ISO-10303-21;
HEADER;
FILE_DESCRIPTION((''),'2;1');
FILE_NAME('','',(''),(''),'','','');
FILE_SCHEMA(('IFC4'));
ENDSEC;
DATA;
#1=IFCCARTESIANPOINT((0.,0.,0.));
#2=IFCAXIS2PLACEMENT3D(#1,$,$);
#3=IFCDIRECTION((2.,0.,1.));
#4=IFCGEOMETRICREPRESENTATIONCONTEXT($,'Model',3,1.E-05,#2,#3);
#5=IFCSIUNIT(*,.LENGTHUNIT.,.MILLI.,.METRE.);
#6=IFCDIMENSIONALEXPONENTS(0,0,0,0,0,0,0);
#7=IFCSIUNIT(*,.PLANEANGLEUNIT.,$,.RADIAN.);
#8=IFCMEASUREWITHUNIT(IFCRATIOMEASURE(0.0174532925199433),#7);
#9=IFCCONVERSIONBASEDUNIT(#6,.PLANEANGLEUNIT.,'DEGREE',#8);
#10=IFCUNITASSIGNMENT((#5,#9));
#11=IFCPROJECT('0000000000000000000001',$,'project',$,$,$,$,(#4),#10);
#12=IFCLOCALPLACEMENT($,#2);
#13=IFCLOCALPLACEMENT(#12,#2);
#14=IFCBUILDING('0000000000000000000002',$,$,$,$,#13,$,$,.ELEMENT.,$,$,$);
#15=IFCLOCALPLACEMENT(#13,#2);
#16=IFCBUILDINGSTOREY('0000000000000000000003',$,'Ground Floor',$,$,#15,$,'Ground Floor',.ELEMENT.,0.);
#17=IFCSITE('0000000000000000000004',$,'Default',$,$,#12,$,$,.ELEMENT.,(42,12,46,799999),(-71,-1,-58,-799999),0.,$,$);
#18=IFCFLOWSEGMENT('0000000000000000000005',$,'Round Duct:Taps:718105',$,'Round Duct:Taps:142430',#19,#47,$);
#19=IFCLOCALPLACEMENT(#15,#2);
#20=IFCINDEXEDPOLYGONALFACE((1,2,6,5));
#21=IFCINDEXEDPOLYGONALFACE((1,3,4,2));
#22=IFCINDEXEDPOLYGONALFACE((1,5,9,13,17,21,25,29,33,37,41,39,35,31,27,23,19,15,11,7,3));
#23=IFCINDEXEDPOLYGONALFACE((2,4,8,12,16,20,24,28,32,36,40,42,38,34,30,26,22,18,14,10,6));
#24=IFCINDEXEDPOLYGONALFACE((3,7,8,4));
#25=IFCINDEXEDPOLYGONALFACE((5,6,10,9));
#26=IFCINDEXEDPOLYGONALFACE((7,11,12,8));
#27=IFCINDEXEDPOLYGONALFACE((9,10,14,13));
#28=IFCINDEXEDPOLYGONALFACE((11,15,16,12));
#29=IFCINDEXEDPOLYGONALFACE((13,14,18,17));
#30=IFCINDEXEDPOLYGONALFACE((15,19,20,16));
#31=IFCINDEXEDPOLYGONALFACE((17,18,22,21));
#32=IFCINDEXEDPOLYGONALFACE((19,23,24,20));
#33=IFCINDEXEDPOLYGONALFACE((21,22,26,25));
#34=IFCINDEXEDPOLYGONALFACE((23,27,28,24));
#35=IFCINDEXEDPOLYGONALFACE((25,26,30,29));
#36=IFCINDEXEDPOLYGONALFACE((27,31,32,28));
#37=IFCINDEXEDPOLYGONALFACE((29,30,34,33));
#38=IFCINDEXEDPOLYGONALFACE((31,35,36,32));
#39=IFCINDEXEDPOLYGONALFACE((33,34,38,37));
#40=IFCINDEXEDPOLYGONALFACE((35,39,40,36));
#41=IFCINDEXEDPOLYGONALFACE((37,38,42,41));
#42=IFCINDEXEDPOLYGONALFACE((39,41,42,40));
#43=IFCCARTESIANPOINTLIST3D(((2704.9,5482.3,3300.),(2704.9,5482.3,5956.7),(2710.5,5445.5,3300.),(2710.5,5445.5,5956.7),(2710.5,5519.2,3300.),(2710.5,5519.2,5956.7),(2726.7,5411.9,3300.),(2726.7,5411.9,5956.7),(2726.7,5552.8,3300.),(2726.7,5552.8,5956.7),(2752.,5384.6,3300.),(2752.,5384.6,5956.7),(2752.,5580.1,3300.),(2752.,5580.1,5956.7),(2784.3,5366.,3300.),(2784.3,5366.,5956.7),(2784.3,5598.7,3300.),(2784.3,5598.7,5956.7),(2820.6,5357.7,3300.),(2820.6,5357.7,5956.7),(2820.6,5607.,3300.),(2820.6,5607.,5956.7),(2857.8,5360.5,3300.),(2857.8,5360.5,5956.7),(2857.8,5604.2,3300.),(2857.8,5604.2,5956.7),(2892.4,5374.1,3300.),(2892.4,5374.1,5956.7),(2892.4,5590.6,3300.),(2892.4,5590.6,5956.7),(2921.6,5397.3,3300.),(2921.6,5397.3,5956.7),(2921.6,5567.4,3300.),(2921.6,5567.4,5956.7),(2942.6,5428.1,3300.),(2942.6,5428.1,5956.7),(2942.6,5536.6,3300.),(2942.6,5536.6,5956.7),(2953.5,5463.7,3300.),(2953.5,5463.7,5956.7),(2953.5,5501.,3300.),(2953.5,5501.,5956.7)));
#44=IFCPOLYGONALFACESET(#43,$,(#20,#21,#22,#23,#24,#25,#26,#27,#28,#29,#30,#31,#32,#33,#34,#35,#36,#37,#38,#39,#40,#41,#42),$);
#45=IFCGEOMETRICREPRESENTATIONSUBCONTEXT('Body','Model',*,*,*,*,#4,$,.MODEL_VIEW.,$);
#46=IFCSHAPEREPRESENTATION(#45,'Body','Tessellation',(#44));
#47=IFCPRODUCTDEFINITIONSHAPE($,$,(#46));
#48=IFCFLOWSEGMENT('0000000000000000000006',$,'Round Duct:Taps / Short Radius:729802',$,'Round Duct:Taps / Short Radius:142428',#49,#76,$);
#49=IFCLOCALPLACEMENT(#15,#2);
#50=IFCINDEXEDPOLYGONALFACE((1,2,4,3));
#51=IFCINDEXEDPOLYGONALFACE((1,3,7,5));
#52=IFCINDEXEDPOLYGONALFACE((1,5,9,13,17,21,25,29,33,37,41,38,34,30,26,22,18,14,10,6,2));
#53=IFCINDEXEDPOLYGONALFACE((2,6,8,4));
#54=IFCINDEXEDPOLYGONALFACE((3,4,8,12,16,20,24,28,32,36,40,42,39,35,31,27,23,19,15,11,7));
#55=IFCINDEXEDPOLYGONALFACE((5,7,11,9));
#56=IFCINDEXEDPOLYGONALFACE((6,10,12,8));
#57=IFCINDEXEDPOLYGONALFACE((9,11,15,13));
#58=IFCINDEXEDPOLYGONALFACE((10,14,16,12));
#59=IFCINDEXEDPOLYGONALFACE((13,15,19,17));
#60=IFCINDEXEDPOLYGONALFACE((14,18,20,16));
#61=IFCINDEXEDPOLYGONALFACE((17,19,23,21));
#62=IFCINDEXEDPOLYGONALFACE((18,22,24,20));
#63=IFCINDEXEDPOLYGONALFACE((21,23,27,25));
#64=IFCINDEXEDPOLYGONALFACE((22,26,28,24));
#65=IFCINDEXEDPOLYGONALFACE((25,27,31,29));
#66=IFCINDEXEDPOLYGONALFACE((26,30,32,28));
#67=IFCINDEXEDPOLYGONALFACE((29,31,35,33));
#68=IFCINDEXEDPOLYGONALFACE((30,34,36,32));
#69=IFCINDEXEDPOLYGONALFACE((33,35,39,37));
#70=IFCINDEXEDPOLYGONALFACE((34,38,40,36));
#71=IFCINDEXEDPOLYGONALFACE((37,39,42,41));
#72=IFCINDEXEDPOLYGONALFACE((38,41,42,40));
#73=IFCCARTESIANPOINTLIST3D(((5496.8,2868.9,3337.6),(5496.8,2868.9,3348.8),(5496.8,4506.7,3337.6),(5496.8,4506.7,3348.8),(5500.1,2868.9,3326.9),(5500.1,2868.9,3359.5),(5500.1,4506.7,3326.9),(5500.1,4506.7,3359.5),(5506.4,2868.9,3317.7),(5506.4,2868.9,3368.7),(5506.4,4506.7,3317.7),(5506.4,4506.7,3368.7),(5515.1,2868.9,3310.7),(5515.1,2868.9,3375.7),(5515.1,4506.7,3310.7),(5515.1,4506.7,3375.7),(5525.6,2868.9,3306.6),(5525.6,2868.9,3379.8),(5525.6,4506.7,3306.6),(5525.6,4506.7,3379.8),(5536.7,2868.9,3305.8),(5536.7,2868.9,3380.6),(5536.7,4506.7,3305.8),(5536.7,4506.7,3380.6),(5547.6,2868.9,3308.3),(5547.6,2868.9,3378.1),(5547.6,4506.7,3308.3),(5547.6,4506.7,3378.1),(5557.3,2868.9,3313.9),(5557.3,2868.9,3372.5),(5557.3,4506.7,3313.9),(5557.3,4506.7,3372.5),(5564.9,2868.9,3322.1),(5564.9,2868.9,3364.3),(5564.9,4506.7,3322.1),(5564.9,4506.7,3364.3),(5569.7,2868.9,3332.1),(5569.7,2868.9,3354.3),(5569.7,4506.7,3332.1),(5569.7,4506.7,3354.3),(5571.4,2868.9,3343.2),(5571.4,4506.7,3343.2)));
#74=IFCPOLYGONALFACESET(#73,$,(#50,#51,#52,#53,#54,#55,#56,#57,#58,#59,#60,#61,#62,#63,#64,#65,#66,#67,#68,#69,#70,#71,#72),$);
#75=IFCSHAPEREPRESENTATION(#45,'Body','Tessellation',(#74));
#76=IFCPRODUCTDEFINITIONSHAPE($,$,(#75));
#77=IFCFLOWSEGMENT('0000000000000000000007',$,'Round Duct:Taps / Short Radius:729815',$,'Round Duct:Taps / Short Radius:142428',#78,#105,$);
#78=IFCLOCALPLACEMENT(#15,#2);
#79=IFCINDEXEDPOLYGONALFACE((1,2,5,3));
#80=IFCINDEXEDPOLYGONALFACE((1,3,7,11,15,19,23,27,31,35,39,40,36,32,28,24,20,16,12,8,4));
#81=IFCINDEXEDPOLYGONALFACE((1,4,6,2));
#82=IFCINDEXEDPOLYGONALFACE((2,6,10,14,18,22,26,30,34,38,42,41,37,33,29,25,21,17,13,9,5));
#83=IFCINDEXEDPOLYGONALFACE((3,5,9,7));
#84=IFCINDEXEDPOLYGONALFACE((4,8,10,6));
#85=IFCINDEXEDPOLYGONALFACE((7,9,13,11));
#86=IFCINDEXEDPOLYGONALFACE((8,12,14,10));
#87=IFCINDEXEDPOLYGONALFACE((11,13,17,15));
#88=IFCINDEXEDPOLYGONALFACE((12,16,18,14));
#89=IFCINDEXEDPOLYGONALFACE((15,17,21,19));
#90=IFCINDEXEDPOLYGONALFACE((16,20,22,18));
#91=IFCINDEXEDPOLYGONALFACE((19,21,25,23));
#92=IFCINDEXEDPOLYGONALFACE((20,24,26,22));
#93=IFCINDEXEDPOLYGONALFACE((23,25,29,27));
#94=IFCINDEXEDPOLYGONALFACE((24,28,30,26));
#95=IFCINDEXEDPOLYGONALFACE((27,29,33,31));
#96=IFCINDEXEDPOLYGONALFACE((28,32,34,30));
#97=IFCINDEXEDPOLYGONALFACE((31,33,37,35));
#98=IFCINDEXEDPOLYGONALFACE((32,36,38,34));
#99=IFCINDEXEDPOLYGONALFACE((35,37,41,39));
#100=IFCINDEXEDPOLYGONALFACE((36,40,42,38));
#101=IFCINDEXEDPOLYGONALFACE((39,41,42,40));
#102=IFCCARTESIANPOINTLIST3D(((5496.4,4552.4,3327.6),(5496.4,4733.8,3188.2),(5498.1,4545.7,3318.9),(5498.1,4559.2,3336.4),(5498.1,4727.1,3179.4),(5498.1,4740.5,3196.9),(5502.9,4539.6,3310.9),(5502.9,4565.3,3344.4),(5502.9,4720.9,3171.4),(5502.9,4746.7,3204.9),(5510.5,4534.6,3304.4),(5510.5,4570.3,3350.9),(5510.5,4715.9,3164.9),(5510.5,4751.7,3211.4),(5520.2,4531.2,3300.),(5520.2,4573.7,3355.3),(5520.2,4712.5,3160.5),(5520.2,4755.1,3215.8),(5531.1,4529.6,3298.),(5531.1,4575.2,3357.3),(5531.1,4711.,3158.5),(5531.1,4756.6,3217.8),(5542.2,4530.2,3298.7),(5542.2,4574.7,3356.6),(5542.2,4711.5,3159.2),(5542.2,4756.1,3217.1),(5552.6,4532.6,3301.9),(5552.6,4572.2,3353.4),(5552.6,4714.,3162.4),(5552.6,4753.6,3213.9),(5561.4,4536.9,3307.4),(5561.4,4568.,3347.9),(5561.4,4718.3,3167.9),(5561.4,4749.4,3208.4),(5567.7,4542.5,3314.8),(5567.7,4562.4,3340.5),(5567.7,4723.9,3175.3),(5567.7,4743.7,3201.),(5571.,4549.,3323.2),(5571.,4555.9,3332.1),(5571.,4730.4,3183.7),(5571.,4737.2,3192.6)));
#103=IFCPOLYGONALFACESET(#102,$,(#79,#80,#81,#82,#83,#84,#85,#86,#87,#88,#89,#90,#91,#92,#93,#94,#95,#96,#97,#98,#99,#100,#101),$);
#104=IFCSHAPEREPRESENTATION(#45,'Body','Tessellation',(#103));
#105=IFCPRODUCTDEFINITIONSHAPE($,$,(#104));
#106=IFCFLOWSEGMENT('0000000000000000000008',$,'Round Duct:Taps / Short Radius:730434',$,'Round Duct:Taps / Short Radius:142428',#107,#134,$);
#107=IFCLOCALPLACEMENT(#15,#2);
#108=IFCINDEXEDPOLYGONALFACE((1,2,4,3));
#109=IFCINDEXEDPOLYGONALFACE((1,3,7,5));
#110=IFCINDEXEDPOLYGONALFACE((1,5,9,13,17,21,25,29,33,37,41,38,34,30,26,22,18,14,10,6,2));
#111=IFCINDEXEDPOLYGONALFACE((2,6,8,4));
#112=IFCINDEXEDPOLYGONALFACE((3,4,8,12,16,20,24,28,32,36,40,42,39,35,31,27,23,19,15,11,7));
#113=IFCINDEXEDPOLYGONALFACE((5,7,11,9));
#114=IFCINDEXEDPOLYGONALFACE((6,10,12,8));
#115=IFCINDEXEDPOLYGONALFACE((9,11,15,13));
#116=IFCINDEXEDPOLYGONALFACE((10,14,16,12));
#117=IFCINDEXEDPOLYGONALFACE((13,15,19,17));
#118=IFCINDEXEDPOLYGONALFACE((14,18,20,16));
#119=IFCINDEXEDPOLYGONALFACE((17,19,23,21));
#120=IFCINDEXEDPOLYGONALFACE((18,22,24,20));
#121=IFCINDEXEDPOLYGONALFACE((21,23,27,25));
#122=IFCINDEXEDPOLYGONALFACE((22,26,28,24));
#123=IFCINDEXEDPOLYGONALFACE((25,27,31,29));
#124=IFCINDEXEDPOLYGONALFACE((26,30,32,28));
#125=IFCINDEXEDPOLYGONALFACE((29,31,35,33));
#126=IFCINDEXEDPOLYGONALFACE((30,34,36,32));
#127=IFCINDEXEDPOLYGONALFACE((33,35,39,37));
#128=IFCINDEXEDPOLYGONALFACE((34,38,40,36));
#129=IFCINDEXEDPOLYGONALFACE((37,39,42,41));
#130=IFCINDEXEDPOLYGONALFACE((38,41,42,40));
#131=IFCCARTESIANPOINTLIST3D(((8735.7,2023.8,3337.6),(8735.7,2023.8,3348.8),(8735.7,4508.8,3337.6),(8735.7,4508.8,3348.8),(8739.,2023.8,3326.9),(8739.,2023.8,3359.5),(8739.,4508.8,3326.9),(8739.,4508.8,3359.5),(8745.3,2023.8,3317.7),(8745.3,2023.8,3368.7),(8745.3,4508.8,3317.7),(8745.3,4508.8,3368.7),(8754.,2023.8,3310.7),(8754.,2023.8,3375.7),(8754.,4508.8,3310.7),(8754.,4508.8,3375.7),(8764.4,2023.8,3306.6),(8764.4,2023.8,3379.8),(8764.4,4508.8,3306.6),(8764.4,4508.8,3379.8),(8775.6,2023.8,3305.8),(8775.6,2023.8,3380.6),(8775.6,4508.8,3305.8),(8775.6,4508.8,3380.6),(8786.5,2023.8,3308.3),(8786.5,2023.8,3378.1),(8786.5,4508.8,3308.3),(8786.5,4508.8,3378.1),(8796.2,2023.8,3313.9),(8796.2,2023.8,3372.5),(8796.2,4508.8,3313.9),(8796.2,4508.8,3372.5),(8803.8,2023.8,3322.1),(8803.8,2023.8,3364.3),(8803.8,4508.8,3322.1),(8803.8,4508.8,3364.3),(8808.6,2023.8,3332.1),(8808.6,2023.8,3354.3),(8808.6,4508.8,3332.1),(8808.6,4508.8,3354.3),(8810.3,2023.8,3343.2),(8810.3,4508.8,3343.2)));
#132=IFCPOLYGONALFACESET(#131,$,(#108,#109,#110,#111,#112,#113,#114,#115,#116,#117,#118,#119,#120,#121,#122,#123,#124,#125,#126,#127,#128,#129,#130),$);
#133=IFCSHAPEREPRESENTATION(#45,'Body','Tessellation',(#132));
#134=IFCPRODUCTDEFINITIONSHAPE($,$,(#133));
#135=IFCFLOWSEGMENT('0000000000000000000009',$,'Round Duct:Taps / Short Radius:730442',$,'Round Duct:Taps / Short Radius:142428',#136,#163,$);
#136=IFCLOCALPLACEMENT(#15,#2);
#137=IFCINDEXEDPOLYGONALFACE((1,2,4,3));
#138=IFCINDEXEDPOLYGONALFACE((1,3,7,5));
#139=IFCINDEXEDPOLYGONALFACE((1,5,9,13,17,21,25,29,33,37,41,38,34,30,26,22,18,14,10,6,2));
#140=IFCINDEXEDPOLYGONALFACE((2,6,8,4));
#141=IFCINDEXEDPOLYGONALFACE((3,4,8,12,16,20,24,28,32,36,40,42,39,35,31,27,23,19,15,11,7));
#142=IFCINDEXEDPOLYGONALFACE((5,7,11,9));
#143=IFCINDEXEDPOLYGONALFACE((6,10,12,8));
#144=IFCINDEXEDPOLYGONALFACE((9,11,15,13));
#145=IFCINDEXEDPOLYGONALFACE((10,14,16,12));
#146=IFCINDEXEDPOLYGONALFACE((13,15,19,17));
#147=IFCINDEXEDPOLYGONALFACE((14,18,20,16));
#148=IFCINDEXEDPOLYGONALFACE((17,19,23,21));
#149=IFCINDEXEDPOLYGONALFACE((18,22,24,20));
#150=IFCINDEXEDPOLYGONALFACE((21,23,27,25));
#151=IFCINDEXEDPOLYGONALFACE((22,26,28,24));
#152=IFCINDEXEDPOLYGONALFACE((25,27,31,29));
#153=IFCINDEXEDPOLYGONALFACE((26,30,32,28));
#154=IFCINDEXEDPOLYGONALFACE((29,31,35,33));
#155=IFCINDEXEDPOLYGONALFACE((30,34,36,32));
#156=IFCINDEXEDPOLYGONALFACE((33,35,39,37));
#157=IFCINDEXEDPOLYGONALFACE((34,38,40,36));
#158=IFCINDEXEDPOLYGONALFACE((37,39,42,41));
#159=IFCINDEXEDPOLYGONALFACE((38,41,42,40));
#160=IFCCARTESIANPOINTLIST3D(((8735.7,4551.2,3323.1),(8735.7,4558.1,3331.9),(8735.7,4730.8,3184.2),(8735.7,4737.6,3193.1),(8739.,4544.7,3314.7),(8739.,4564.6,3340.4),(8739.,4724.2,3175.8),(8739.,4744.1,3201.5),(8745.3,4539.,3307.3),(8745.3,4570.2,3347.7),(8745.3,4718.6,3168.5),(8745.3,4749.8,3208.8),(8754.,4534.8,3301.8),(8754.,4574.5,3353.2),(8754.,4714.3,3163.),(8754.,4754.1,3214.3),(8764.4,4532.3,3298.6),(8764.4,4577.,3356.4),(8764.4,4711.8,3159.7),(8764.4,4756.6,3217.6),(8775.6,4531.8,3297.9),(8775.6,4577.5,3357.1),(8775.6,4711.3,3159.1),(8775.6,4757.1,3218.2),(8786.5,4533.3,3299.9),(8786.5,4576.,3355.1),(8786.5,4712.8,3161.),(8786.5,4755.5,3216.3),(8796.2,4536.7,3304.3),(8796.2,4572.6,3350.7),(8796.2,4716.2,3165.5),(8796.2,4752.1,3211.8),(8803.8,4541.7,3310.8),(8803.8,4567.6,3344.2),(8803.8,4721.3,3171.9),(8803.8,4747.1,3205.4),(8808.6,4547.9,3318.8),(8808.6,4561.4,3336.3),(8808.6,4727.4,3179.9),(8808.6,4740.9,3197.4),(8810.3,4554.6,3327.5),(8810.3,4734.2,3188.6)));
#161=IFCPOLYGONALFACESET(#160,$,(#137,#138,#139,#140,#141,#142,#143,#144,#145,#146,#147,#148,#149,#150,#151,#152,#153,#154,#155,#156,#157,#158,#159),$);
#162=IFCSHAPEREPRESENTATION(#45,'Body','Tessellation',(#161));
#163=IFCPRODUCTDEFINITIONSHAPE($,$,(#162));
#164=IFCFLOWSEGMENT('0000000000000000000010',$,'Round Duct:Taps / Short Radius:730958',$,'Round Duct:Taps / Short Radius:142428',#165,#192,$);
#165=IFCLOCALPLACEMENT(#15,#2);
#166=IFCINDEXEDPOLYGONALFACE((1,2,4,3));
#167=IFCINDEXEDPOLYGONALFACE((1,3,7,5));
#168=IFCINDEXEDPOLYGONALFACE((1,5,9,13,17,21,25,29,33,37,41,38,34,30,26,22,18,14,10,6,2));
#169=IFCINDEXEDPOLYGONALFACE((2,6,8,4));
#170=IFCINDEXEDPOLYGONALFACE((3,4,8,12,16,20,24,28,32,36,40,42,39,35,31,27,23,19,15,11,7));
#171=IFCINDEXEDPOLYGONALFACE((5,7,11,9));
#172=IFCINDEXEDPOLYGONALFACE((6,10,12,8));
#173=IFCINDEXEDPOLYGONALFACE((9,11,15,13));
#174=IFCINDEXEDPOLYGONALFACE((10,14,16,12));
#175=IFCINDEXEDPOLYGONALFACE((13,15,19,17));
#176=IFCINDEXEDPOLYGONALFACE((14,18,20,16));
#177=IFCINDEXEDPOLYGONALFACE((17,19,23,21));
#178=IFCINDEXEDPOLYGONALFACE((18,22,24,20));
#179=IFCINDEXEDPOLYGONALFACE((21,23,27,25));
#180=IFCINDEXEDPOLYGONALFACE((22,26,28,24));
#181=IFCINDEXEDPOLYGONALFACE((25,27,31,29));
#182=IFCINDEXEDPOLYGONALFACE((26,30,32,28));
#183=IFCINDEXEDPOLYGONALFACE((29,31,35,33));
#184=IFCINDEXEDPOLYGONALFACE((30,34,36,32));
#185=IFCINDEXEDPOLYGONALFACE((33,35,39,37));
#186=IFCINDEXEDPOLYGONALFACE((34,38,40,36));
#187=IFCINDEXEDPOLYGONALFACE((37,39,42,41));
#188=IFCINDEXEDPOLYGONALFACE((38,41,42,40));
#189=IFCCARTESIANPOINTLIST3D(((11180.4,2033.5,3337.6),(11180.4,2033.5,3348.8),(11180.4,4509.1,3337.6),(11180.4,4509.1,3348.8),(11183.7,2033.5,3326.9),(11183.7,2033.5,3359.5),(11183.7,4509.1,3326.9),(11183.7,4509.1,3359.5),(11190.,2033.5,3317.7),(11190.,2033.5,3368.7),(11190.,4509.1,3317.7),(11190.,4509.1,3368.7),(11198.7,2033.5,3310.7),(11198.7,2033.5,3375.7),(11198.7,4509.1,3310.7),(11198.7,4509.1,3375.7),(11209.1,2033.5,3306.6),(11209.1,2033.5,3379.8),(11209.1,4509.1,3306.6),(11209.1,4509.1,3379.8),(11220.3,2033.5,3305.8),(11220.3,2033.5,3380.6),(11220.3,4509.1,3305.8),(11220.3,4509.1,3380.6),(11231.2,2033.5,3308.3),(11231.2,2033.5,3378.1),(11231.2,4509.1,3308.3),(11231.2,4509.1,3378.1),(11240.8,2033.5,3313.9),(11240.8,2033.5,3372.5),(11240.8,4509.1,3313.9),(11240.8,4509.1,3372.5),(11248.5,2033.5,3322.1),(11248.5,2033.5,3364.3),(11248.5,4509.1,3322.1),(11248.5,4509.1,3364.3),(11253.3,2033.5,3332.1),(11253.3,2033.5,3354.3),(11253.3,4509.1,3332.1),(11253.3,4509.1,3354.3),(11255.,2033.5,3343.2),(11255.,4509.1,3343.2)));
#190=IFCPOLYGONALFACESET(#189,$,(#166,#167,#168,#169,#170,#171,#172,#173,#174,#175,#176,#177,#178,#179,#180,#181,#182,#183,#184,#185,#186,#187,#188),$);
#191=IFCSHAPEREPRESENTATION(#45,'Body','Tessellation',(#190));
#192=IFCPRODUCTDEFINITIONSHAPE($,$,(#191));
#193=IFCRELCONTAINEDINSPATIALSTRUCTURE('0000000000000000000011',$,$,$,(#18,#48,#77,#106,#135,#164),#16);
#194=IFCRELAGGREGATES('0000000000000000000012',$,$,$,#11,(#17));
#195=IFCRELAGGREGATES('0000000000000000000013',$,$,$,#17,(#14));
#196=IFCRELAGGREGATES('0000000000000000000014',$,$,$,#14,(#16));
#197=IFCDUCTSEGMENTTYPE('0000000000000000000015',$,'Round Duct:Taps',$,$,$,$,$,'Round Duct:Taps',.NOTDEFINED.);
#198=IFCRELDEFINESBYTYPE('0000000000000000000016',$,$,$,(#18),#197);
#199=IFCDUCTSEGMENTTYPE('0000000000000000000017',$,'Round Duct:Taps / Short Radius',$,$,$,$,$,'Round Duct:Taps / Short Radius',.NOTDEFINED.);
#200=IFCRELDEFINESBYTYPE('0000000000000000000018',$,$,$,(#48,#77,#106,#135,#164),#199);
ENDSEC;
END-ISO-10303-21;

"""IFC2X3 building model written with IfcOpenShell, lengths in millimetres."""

from ifc_helpers import new_model, entity, si_unit, converted_unit, direction, frame, frame_2d, origin, origin_2d_with_axis, place, context, subcontext, project, spatial, circle, extrude, type_object, element, save


model = new_model("IFC2X3")

# Units and contexts
model_context = context("Model", 3, precision=1e-05, world=origin(), true_north=direction((2.0, 0.0, 1.0)))
body_context = subcontext(model_context, "Body", "Model", "MODEL_VIEW")
ifc_project = project(units=[si_unit("LENGTHUNIT", "METRE", prefix="MILLI"), converted_unit("PLANEANGLEUNIT", "DEGREE", entity("IfcRatioMeasure", 0.0174532925199433), si_unit("PLANEANGLEUNIT", "RADIAN"), dimensions=[0, 0, 0, 0, 0, 0, 0])], contexts=[model_context])

# Site, building, storey
site_placement = place(None, origin())
site = spatial("IfcSite", under=ifc_project, at=site_placement, Name="Default", CompositionType="ELEMENT", RefLatitude=(42, 12, 46, 799999), RefLongitude=(-71, -1, -58, -799999), RefElevation=0.0)
building_placement = place(site_placement, origin())
building = spatial("IfcBuilding", under=site, at=building_placement, CompositionType="ELEMENT")
storey_placement = place(building_placement, origin())
storey = spatial("IfcBuildingStorey", under=building, at=storey_placement, Name="Ground Floor", LongName="Ground Floor", CompositionType="ELEMENT", Elevation=0.0)

# Flow segments
duct_segment_type_1 = type_object("IfcDuctSegmentType", Name="Round Duct:Taps", ElementType="Round Duct:Taps", PredefinedType="NOTDEFINED")
flow_segment_1_placement = place(storey_placement, origin())
element("IfcFlowSegment", 1, at=flow_segment_1_placement, inside=storey, type_object=duct_segment_type_1, Name="Round Duct:Taps:718105", ObjectType="Round Duct:Taps:142430", context=body_context, shape_type="SweptSolid", body=[
    extrude(circle(Radius=125.0, at=frame_2d((0.0, 0.0), x_axis=(1.0, 0.0))), frame((2829.9, 5482.3, 3300.0), z_axis=(0.0, 0.0, 1.0), x_axis=(-1.0, 0.0, 0.0)), (0.0, 0.0, 1.0), 2656.7),
])
duct_segment_type_2 = type_object("IfcDuctSegmentType", Name="Round Duct:Taps / Short Radius", ElementType="Round Duct:Taps / Short Radius", PredefinedType="NOTDEFINED")
flow_segment_2_placement = place(storey_placement, origin())
element("IfcFlowSegment", 2, at=flow_segment_2_placement, inside=storey, type_object=duct_segment_type_2, Name="Round Duct:Taps / Short Radius:729802", ObjectType="Round Duct:Taps / Short Radius:142428", context=body_context, shape_type="SweptSolid", body=[
    extrude(circle(Radius=37.5, at=frame_2d((0.0, 0.0), x_axis=(1.0, 0.0))), frame((5533.9, 2868.9, 3343.2), z_axis=(0.0, 1.0, 0.0), x_axis=(1.0, 0.0, 0.0)), (0.0, 0.0, 1.0), 1637.9),
])
flow_segment_3_placement = place(storey_placement, origin())
element("IfcFlowSegment", 3, at=flow_segment_3_placement, inside=storey, type_object=duct_segment_type_2, Name="Round Duct:Taps / Short Radius:729815", ObjectType="Round Duct:Taps / Short Radius:142428", context=body_context, shape_type="SweptSolid", body=[
    extrude(circle(Radius=37.5, at=frame_2d((0.0, 0.0), x_axis=(1.0, 0.0))), frame((5533.9, 4552.4, 3327.6), z_axis=(0.0, 0.792649, -0.609678), x_axis=(-1.0, 0.0, 0.0)), (0.0, 0.0, 1.0), 228.8),
])
flow_segment_4_placement = place(storey_placement, origin())
element("IfcFlowSegment", 4, at=flow_segment_4_placement, inside=storey, type_object=duct_segment_type_2, Name="Round Duct:Taps / Short Radius:730434", ObjectType="Round Duct:Taps / Short Radius:142428", context=body_context, shape_type="SweptSolid", body=[
    extrude(circle(Radius=37.5, at=origin_2d_with_axis()), frame((8772.8, 2023.8, 3343.2), z_axis=(0.0, 1.0, 0.0), x_axis=(1.0, 0.0, 0.0)), (0.0, 0.0, 1.0), 2484.9),
])
flow_segment_5_placement = place(storey_placement, origin())
element("IfcFlowSegment", 5, at=flow_segment_5_placement, inside=storey, type_object=duct_segment_type_2, Name="Round Duct:Taps / Short Radius:730442", ObjectType="Round Duct:Taps / Short Radius:142428", context=body_context, shape_type="SweptSolid", body=[
    extrude(circle(Radius=37.5, at=frame_2d((0.0, 0.0), x_axis=(1.0, 0.0))), frame((8772.8, 4554.6, 3327.5), z_axis=(0.0, 0.790984, -0.611837), x_axis=(1.0, 0.0, 0.0)), (0.0, 0.0, 1.0), 227.0),
])
flow_segment_6_placement = place(storey_placement, origin())
element("IfcFlowSegment", 6, at=flow_segment_6_placement, inside=storey, type_object=duct_segment_type_2, Name="Round Duct:Taps / Short Radius:730958", ObjectType="Round Duct:Taps / Short Radius:142428", context=body_context, shape_type="SweptSolid", body=[
    extrude(circle(Radius=37.5, at=frame_2d((0.0, 0.0), x_axis=(1.0, 0.0))), frame((11217.5, 2033.5, 3343.2), z_axis=(0.0, 1.0, 0.0), x_axis=(1.0, 0.0, 0.0)), (0.0, 0.0, 1.0), 2475.6),
])

save(model, "model.ifc")
